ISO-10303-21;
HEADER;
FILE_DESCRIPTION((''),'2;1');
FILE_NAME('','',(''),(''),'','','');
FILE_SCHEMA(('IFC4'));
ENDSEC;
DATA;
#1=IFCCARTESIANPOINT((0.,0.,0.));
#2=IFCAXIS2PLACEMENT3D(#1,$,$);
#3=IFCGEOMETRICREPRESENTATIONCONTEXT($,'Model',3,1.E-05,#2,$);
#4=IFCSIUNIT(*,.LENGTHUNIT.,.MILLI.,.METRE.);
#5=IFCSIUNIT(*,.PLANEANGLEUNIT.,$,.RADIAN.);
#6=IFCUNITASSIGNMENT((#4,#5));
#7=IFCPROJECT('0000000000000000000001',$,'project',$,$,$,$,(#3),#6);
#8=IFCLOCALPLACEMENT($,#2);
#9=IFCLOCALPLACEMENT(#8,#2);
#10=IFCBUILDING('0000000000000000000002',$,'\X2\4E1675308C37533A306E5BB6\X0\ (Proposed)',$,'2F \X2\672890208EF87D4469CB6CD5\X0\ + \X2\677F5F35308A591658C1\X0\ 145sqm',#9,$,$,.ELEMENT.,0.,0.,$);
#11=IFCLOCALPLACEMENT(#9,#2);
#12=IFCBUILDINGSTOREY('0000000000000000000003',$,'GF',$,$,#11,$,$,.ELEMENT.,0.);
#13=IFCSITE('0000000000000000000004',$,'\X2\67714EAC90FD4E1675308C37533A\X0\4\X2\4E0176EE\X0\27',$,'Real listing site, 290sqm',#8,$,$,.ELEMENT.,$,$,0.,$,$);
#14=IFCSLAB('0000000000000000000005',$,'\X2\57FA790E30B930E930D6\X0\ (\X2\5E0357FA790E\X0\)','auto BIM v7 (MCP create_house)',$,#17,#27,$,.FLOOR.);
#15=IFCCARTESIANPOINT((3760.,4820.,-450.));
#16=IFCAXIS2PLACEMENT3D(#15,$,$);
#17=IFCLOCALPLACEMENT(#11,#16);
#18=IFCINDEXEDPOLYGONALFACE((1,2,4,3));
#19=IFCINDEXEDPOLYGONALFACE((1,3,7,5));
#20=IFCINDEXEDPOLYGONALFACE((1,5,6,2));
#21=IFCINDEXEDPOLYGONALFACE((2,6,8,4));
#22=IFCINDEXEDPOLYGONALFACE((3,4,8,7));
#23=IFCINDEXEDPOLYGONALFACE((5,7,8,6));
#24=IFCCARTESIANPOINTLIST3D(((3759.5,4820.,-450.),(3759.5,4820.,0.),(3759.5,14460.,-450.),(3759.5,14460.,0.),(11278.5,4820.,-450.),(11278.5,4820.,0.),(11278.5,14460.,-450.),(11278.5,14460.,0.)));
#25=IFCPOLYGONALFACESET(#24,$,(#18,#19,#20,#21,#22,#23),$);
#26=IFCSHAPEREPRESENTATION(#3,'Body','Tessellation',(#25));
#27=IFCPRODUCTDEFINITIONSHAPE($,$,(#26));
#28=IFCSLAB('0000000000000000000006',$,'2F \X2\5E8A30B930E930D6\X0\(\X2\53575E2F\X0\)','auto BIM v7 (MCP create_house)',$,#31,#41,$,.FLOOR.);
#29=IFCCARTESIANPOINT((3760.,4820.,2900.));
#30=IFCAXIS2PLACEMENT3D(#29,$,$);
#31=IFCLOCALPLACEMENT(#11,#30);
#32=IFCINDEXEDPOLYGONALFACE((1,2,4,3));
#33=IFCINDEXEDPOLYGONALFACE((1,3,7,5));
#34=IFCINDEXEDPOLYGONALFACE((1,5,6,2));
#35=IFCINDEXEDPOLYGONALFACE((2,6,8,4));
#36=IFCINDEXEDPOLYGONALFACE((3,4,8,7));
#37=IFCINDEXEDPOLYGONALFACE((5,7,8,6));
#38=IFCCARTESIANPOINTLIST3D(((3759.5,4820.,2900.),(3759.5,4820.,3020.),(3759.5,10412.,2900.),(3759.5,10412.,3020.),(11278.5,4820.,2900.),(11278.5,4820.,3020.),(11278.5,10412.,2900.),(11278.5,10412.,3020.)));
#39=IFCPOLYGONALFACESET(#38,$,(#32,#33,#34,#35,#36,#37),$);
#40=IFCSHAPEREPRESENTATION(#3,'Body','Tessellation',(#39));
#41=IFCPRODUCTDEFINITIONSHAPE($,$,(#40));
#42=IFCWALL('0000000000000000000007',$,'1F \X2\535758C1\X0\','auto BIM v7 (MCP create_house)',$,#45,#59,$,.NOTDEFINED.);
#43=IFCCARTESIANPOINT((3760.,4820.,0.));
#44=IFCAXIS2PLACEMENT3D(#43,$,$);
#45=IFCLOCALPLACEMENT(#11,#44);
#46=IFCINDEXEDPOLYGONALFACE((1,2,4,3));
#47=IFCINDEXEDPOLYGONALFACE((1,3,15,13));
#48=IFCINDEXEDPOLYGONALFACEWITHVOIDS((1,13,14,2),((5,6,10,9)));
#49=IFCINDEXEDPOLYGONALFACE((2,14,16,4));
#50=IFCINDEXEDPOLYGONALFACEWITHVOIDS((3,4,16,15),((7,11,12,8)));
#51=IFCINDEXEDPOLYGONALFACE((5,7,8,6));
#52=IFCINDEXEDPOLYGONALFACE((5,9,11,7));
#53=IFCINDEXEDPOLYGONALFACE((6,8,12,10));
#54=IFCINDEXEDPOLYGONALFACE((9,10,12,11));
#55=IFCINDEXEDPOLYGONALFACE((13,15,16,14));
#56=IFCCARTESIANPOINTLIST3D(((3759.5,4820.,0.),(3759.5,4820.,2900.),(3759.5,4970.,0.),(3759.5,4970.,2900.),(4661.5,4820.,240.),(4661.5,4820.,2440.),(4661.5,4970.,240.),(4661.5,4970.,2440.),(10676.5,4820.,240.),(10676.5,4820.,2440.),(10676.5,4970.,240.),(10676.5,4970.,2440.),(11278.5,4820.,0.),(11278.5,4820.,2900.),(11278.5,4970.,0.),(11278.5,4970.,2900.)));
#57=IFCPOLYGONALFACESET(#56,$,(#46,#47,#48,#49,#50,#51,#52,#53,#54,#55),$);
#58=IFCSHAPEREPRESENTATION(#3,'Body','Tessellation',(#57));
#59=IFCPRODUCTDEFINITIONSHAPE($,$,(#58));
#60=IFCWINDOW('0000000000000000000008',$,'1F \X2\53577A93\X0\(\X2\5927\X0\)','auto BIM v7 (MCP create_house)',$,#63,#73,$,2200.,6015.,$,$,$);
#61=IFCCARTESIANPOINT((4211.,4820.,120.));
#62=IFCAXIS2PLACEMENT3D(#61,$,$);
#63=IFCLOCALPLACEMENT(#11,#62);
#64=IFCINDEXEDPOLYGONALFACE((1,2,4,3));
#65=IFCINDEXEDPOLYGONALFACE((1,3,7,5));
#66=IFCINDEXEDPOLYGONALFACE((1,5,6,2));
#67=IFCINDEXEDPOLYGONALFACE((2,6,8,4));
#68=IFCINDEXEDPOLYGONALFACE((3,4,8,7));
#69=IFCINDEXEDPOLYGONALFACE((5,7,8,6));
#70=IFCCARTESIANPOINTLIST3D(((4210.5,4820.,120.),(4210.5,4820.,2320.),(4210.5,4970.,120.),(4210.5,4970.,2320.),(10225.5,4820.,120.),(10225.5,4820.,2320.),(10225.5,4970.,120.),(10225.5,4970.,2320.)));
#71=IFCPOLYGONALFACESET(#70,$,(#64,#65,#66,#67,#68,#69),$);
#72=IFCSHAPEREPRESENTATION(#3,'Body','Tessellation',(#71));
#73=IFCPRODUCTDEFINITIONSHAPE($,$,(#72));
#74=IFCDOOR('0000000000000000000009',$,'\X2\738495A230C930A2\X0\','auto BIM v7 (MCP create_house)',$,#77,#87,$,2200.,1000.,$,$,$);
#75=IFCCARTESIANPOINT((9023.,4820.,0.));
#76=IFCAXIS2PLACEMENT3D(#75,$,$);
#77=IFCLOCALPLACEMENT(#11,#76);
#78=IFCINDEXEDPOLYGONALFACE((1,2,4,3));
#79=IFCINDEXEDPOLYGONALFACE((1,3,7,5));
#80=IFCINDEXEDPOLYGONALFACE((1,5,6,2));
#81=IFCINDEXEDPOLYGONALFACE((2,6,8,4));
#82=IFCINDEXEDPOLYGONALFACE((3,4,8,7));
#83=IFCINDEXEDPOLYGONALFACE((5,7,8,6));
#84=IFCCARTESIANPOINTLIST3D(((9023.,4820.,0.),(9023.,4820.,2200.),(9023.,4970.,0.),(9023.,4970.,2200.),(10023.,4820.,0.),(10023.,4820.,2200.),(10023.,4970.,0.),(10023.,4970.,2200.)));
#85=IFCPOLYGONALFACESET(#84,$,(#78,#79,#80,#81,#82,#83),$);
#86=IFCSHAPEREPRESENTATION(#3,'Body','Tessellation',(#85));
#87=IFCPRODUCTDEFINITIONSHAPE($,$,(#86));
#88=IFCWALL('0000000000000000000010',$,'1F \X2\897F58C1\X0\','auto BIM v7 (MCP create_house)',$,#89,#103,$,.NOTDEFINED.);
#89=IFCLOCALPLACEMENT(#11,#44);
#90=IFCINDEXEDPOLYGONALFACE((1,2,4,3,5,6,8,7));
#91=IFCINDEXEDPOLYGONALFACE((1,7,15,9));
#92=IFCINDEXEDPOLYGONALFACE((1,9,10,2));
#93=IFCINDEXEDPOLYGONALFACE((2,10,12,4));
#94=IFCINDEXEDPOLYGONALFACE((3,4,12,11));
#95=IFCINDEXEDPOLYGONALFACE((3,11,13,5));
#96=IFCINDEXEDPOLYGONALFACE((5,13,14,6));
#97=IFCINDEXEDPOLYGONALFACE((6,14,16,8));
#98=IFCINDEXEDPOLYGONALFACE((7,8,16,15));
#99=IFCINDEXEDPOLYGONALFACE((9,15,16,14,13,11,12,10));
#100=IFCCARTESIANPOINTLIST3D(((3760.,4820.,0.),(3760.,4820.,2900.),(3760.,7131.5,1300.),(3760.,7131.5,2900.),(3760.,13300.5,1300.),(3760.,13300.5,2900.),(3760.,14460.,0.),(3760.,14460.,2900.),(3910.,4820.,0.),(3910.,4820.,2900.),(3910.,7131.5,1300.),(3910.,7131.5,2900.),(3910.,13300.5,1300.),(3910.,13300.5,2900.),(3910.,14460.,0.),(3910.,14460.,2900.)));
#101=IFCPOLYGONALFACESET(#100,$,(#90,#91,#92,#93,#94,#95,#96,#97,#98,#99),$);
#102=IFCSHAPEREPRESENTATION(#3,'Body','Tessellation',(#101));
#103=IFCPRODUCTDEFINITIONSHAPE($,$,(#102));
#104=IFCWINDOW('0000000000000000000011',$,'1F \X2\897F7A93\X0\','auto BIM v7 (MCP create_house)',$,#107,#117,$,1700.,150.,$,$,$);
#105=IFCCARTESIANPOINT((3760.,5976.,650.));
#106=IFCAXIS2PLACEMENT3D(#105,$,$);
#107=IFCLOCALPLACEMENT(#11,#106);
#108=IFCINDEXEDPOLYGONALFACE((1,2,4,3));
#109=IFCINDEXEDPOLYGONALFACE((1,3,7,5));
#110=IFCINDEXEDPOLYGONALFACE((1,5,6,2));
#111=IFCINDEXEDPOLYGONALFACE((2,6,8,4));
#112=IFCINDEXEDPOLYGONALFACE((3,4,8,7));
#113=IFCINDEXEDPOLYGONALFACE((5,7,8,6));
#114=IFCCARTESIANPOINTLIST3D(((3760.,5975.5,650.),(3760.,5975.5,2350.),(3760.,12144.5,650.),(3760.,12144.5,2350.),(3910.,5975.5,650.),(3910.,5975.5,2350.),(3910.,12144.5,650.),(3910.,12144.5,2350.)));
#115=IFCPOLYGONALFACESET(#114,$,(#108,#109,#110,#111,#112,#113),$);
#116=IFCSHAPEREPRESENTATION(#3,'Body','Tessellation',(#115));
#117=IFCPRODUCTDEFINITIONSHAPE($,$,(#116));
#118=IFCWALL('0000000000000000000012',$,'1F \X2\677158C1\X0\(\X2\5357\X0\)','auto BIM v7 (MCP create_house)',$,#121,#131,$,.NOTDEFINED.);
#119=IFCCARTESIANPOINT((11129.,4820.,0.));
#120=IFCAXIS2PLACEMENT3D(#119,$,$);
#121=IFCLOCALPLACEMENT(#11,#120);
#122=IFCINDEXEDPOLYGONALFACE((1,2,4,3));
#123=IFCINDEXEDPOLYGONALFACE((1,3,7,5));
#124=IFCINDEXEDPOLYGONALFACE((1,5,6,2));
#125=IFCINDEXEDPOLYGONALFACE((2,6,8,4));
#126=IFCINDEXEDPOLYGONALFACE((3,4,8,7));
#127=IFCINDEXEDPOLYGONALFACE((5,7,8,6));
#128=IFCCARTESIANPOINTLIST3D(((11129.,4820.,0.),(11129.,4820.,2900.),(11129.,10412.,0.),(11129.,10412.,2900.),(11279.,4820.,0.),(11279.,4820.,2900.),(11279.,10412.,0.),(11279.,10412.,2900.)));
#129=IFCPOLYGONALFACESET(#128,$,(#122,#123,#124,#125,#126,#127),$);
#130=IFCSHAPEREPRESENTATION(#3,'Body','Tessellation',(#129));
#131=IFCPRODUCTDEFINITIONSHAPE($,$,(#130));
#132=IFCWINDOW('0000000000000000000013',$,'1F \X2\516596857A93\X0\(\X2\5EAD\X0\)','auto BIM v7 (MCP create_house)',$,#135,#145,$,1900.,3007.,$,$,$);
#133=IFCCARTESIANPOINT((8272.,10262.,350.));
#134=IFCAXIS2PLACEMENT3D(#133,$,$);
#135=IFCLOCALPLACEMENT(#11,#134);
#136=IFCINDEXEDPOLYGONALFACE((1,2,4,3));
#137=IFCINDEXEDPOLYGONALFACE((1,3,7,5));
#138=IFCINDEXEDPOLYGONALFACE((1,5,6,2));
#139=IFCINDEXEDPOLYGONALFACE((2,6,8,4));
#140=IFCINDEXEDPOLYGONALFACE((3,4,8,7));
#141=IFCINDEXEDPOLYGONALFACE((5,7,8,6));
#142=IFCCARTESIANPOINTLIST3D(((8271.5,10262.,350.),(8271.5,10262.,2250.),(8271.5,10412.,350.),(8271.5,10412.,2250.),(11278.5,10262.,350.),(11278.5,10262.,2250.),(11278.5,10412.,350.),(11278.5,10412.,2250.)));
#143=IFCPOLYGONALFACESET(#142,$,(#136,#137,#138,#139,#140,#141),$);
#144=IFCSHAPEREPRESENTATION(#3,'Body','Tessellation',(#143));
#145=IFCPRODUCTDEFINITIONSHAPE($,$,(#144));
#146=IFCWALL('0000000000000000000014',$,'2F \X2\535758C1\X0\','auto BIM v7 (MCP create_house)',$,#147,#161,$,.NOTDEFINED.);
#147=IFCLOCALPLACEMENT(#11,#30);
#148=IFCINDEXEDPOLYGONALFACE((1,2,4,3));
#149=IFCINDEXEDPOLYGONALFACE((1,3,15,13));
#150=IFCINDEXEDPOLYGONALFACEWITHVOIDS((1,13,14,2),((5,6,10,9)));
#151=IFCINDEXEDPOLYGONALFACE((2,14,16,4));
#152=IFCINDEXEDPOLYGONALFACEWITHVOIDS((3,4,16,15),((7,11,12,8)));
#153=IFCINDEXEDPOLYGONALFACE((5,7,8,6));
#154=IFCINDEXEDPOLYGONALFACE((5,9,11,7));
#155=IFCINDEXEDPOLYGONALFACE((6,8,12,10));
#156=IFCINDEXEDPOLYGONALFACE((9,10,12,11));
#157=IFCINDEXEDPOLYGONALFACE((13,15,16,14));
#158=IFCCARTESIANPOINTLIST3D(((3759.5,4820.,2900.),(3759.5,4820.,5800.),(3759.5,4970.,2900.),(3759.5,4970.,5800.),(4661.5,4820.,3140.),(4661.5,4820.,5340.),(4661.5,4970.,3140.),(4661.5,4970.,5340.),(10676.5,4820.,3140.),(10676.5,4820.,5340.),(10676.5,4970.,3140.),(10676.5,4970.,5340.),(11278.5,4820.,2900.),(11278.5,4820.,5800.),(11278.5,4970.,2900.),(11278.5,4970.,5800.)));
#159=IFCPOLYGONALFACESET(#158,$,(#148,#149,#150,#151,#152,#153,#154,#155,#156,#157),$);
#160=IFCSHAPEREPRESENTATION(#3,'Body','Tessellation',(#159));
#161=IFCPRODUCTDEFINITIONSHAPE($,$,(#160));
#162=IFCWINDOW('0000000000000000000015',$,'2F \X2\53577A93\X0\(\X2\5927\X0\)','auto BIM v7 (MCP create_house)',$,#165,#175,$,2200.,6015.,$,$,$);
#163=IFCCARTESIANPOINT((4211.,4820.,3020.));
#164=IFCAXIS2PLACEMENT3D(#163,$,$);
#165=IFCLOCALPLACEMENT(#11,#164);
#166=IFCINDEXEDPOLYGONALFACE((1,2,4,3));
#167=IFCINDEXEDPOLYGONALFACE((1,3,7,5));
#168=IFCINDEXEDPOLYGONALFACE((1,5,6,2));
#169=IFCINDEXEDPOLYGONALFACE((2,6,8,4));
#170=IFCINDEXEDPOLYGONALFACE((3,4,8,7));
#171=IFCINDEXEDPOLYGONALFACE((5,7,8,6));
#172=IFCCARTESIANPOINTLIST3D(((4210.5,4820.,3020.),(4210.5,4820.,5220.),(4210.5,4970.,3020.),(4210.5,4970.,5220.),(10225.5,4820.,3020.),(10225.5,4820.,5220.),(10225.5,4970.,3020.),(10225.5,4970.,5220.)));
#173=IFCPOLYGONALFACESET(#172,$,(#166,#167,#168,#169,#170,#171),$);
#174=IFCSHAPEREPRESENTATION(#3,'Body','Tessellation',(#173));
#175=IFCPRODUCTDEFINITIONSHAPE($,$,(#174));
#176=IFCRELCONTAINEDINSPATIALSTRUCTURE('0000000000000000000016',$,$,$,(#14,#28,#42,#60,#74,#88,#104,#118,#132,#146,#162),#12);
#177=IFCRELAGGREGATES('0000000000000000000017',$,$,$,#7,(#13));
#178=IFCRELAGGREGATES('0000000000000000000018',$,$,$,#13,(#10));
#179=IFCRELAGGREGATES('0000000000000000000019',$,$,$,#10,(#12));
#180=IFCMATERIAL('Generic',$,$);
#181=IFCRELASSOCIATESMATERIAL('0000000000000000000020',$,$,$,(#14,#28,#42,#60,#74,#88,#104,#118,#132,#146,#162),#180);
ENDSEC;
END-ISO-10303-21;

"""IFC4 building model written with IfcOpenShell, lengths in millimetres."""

from ifc_helpers import new_model, si_unit, frame, frame_2d, origin, place, context, project, spatial, rectangle, extrude, material, element, fill, save


model = new_model("IFC4")

# Units and contexts
model_context = context("Model", 3, precision=1e-05, world=origin())
ifc_project = project(units=[si_unit("LENGTHUNIT", "METRE", prefix="MILLI"), si_unit("PLANEANGLEUNIT", "RADIAN")], contexts=[model_context])

# Site, building, storey
site_placement = place(None, origin())
site = spatial("IfcSite", under=ifc_project, at=site_placement, Name="東京都世田谷区4丁目27", ObjectType="Real listing site, 290sqm", CompositionType="ELEMENT", RefElevation=0.0)
building_placement = place(site_placement, origin())
building = spatial("IfcBuilding", under=site, at=building_placement, Name="世田谷区の家 (Proposed)", ObjectType="2F 木造軸組構法 + 板張り外壁 145sqm", CompositionType="ELEMENT", ElevationOfRefHeight=0.0, ElevationOfTerrain=0.0)
storey_placement = place(building_placement, origin())
storey = spatial("IfcBuildingStorey", under=building, at=storey_placement, Name="GF", CompositionType="ELEMENT", Elevation=0.0)

# Slabs
ifc_material = material(Name="Generic")
slab_1_placement = place(storey_placement, frame((3760.0, 4820.0, -450.0)))
element("IfcSlab", 1, at=slab_1_placement, inside=storey, material=ifc_material, Name="基礎スラブ (布基礎)", Description="auto BIM v7 (MCP create_house)", PredefinedType="FLOOR", context=model_context, shape_type="SweptSolid", body=[
    extrude(rectangle(XDim=7519.0, YDim=9640.0, at=frame_2d((3759.0, 4820.0))), frame((3760.0, 4820.0, -450.0)), (0.0, 0.0, 1.0), 450.0),
])
slab_2_placement = place(storey_placement, frame((3760.0, 4820.0, 2900.0)))
element("IfcSlab", 2, at=slab_2_placement, inside=storey, material=ifc_material, Name="2F 床スラブ(南帯)", Description="auto BIM v7 (MCP create_house)", PredefinedType="FLOOR", context=model_context, shape_type="SweptSolid", body=[
    extrude(rectangle(XDim=7519.0, YDim=5592.0, at=frame_2d((3759.0, 2796.0))), frame((3760.0, 4820.0, 2900.0)), (0.0, 0.0, 1.0), 120.0),
])

# Wall, openings, window, door
wall_1_placement = place(storey_placement, frame((3760.0, 4820.0, 0.0)))
wall_1 = element("IfcWall", 3, at=wall_1_placement, inside=storey, material=ifc_material, Name="1F 南壁", Description="auto BIM v7 (MCP create_house)", PredefinedType="NOTDEFINED", context=model_context, shape_type="SweptSolid", body=[
    extrude(rectangle(XDim=7519.0, YDim=150.0, at=frame_2d((3759.0, 75.0))), frame((3760.0, 4820.0, 0.0)), (0.0, 0.0, 1.0), 2900.0),
])
opening_1_placement = place(storey_placement, frame((4211.0, 4820.0, 120.0)))
opening_1 = element("IfcOpeningElement", 4, at=opening_1_placement, cuts=wall_1, PredefinedType="NOTDEFINED", context=model_context, shape_type="SweptSolid", body=[
    extrude(rectangle(XDim=6015.0, YDim=150.0, at=frame_2d((3007.0, 75.0))), frame((4211.0, 4820.0, 120.0)), (0.0, 0.0, 1.0), 2200.0),
])
opening_2_placement = place(storey_placement, frame((9023.0, 4820.0, 0.0)))
opening_2 = element("IfcOpeningElement", 5, at=opening_2_placement, cuts=wall_1, PredefinedType="NOTDEFINED", context=model_context, shape_type="SweptSolid", body=[
    extrude(rectangle(XDim=1000.0, YDim=150.0, at=frame_2d((500.0, 75.0))), frame((9023.0, 4820.0, 0.0)), (0.0, 0.0, 1.0), 2200.0),
])
window_1_placement = place(storey_placement, frame((4211.0, 4820.0, 120.0)))
window_1 = element("IfcWindow", 6, at=window_1_placement, inside=storey, material=ifc_material, Name="1F 南窓(大)", Description="auto BIM v7 (MCP create_house)", OverallHeight=2200.0, OverallWidth=6015.0, context=model_context, shape_type="SweptSolid", body=[
    extrude(rectangle(XDim=6015.0, YDim=150.0, at=frame_2d((3007.0, 75.0))), frame((4211.0, 4820.0, 120.0)), (0.0, 0.0, 1.0), 2200.0),
])
fill(opening_1, window_1)
door_placement = place(storey_placement, frame((9023.0, 4820.0, 0.0)))
door = element("IfcDoor", 7, at=door_placement, inside=storey, material=ifc_material, Name="玄関ドア", Description="auto BIM v7 (MCP create_house)", OverallHeight=2200.0, OverallWidth=1000.0, context=model_context, shape_type="SweptSolid", body=[
    extrude(rectangle(XDim=1000.0, YDim=150.0, at=frame_2d((500.0, 75.0))), frame((9023.0, 4820.0, 0.0)), (0.0, 0.0, 1.0), 2200.0),
])
fill(opening_2, door)

# Walls, openings, windows
wall_2_placement = place(storey_placement, frame((3760.0, 4820.0, 0.0)))
wall_2 = element("IfcWall", 8, at=wall_2_placement, inside=storey, material=ifc_material, Name="1F 西壁", Description="auto BIM v7 (MCP create_house)", PredefinedType="NOTDEFINED", context=model_context, shape_type="SweptSolid", body=[
    extrude(rectangle(XDim=150.0, YDim=9640.0, at=frame_2d((75.0, 4820.0))), frame((3760.0, 4820.0, 0.0)), (0.0, 0.0, 1.0), 2900.0),
])
opening_3_placement = place(storey_placement, frame((3760.0, 5976.0, 650.0)))
opening_3 = element("IfcOpeningElement", 9, at=opening_3_placement, cuts=wall_2, PredefinedType="NOTDEFINED", context=model_context, shape_type="SweptSolid", body=[
    extrude(rectangle(XDim=150.0, YDim=6169.0, at=frame_2d((75.0, 3084.0))), frame((3760.0, 5976.0, 650.0)), (0.0, 0.0, 1.0), 1700.0),
])
window_2_placement = place(storey_placement, frame((3760.0, 5976.0, 650.0)))
window_2 = element("IfcWindow", 10, at=window_2_placement, inside=storey, material=ifc_material, Name="1F 西窓", Description="auto BIM v7 (MCP create_house)", OverallHeight=1700.0, OverallWidth=150.0, context=model_context, shape_type="SweptSolid", body=[
    extrude(rectangle(XDim=150.0, YDim=6169.0, at=frame_2d((75.0, 3084.0))), frame((3760.0, 5976.0, 650.0)), (0.0, 0.0, 1.0), 1700.0),
])
fill(opening_3, window_2)
wall_3_placement = place(storey_placement, frame((11129.0, 4820.0, 0.0)))
wall_3 = element("IfcWall", 11, at=wall_3_placement, inside=storey, material=ifc_material, Name="1F 東壁(南)", Description="auto BIM v7 (MCP create_house)", PredefinedType="NOTDEFINED", context=model_context, shape_type="SweptSolid", body=[
    extrude(rectangle(XDim=150.0, YDim=5592.0, at=frame_2d((75.0, 2796.0))), frame((11129.0, 4820.0, 0.0)), (0.0, 0.0, 1.0), 2900.0),
])
opening_4_placement = place(storey_placement, frame((8272.0, 10262.0, 350.0)))
opening_4 = element("IfcOpeningElement", 12, at=opening_4_placement, cuts=wall_3, PredefinedType="NOTDEFINED", context=model_context, shape_type="SweptSolid", body=[
    extrude(rectangle(XDim=3007.0, YDim=150.0, at=frame_2d((1503.0, 75.0))), frame((8272.0, 10262.0, 350.0)), (0.0, 0.0, 1.0), 1900.0),
])
window_3_placement = place(storey_placement, frame((8272.0, 10262.0, 350.0)))
window_3 = element("IfcWindow", 13, at=window_3_placement, inside=storey, material=ifc_material, Name="1F 入隅窓(庭)", Description="auto BIM v7 (MCP create_house)", OverallHeight=1900.0, OverallWidth=3007.0, context=model_context, shape_type="SweptSolid", body=[
    extrude(rectangle(XDim=3007.0, YDim=150.0, at=frame_2d((1503.0, 75.0))), frame((8272.0, 10262.0, 350.0)), (0.0, 0.0, 1.0), 1900.0),
])
fill(opening_4, window_3)

# Wall, opening, window
wall_4_placement = place(storey_placement, frame((3760.0, 4820.0, 2900.0)))
wall_4 = element("IfcWall", 14, at=wall_4_placement, inside=storey, material=ifc_material, Name="2F 南壁", Description="auto BIM v7 (MCP create_house)", PredefinedType="NOTDEFINED", context=model_context, shape_type="SweptSolid", body=[
    extrude(rectangle(XDim=7519.0, YDim=150.0, at=frame_2d((3759.0, 75.0))), frame((3760.0, 4820.0, 2900.0)), (0.0, 0.0, 1.0), 2900.0),
])
opening_5_placement = place(storey_placement, frame((4211.0, 4820.0, 3020.0)))
opening_5 = element("IfcOpeningElement", 15, at=opening_5_placement, cuts=wall_4, PredefinedType="NOTDEFINED", context=model_context, shape_type="SweptSolid", body=[
    extrude(rectangle(XDim=6015.0, YDim=150.0, at=frame_2d((3007.0, 75.0))), frame((4211.0, 4820.0, 3020.0)), (0.0, 0.0, 1.0), 2200.0),
])
window_4_placement = place(storey_placement, frame((4211.0, 4820.0, 3020.0)))
window_4 = element("IfcWindow", 16, at=window_4_placement, inside=storey, material=ifc_material, Name="2F 南窓(大)", Description="auto BIM v7 (MCP create_house)", OverallHeight=2200.0, OverallWidth=6015.0, context=model_context, shape_type="SweptSolid", body=[
    extrude(rectangle(XDim=6015.0, YDim=150.0, at=frame_2d((3007.0, 75.0))), frame((4211.0, 4820.0, 3020.0)), (0.0, 0.0, 1.0), 2200.0),
])
fill(opening_5, window_4)

save(model, "model.ifc")
